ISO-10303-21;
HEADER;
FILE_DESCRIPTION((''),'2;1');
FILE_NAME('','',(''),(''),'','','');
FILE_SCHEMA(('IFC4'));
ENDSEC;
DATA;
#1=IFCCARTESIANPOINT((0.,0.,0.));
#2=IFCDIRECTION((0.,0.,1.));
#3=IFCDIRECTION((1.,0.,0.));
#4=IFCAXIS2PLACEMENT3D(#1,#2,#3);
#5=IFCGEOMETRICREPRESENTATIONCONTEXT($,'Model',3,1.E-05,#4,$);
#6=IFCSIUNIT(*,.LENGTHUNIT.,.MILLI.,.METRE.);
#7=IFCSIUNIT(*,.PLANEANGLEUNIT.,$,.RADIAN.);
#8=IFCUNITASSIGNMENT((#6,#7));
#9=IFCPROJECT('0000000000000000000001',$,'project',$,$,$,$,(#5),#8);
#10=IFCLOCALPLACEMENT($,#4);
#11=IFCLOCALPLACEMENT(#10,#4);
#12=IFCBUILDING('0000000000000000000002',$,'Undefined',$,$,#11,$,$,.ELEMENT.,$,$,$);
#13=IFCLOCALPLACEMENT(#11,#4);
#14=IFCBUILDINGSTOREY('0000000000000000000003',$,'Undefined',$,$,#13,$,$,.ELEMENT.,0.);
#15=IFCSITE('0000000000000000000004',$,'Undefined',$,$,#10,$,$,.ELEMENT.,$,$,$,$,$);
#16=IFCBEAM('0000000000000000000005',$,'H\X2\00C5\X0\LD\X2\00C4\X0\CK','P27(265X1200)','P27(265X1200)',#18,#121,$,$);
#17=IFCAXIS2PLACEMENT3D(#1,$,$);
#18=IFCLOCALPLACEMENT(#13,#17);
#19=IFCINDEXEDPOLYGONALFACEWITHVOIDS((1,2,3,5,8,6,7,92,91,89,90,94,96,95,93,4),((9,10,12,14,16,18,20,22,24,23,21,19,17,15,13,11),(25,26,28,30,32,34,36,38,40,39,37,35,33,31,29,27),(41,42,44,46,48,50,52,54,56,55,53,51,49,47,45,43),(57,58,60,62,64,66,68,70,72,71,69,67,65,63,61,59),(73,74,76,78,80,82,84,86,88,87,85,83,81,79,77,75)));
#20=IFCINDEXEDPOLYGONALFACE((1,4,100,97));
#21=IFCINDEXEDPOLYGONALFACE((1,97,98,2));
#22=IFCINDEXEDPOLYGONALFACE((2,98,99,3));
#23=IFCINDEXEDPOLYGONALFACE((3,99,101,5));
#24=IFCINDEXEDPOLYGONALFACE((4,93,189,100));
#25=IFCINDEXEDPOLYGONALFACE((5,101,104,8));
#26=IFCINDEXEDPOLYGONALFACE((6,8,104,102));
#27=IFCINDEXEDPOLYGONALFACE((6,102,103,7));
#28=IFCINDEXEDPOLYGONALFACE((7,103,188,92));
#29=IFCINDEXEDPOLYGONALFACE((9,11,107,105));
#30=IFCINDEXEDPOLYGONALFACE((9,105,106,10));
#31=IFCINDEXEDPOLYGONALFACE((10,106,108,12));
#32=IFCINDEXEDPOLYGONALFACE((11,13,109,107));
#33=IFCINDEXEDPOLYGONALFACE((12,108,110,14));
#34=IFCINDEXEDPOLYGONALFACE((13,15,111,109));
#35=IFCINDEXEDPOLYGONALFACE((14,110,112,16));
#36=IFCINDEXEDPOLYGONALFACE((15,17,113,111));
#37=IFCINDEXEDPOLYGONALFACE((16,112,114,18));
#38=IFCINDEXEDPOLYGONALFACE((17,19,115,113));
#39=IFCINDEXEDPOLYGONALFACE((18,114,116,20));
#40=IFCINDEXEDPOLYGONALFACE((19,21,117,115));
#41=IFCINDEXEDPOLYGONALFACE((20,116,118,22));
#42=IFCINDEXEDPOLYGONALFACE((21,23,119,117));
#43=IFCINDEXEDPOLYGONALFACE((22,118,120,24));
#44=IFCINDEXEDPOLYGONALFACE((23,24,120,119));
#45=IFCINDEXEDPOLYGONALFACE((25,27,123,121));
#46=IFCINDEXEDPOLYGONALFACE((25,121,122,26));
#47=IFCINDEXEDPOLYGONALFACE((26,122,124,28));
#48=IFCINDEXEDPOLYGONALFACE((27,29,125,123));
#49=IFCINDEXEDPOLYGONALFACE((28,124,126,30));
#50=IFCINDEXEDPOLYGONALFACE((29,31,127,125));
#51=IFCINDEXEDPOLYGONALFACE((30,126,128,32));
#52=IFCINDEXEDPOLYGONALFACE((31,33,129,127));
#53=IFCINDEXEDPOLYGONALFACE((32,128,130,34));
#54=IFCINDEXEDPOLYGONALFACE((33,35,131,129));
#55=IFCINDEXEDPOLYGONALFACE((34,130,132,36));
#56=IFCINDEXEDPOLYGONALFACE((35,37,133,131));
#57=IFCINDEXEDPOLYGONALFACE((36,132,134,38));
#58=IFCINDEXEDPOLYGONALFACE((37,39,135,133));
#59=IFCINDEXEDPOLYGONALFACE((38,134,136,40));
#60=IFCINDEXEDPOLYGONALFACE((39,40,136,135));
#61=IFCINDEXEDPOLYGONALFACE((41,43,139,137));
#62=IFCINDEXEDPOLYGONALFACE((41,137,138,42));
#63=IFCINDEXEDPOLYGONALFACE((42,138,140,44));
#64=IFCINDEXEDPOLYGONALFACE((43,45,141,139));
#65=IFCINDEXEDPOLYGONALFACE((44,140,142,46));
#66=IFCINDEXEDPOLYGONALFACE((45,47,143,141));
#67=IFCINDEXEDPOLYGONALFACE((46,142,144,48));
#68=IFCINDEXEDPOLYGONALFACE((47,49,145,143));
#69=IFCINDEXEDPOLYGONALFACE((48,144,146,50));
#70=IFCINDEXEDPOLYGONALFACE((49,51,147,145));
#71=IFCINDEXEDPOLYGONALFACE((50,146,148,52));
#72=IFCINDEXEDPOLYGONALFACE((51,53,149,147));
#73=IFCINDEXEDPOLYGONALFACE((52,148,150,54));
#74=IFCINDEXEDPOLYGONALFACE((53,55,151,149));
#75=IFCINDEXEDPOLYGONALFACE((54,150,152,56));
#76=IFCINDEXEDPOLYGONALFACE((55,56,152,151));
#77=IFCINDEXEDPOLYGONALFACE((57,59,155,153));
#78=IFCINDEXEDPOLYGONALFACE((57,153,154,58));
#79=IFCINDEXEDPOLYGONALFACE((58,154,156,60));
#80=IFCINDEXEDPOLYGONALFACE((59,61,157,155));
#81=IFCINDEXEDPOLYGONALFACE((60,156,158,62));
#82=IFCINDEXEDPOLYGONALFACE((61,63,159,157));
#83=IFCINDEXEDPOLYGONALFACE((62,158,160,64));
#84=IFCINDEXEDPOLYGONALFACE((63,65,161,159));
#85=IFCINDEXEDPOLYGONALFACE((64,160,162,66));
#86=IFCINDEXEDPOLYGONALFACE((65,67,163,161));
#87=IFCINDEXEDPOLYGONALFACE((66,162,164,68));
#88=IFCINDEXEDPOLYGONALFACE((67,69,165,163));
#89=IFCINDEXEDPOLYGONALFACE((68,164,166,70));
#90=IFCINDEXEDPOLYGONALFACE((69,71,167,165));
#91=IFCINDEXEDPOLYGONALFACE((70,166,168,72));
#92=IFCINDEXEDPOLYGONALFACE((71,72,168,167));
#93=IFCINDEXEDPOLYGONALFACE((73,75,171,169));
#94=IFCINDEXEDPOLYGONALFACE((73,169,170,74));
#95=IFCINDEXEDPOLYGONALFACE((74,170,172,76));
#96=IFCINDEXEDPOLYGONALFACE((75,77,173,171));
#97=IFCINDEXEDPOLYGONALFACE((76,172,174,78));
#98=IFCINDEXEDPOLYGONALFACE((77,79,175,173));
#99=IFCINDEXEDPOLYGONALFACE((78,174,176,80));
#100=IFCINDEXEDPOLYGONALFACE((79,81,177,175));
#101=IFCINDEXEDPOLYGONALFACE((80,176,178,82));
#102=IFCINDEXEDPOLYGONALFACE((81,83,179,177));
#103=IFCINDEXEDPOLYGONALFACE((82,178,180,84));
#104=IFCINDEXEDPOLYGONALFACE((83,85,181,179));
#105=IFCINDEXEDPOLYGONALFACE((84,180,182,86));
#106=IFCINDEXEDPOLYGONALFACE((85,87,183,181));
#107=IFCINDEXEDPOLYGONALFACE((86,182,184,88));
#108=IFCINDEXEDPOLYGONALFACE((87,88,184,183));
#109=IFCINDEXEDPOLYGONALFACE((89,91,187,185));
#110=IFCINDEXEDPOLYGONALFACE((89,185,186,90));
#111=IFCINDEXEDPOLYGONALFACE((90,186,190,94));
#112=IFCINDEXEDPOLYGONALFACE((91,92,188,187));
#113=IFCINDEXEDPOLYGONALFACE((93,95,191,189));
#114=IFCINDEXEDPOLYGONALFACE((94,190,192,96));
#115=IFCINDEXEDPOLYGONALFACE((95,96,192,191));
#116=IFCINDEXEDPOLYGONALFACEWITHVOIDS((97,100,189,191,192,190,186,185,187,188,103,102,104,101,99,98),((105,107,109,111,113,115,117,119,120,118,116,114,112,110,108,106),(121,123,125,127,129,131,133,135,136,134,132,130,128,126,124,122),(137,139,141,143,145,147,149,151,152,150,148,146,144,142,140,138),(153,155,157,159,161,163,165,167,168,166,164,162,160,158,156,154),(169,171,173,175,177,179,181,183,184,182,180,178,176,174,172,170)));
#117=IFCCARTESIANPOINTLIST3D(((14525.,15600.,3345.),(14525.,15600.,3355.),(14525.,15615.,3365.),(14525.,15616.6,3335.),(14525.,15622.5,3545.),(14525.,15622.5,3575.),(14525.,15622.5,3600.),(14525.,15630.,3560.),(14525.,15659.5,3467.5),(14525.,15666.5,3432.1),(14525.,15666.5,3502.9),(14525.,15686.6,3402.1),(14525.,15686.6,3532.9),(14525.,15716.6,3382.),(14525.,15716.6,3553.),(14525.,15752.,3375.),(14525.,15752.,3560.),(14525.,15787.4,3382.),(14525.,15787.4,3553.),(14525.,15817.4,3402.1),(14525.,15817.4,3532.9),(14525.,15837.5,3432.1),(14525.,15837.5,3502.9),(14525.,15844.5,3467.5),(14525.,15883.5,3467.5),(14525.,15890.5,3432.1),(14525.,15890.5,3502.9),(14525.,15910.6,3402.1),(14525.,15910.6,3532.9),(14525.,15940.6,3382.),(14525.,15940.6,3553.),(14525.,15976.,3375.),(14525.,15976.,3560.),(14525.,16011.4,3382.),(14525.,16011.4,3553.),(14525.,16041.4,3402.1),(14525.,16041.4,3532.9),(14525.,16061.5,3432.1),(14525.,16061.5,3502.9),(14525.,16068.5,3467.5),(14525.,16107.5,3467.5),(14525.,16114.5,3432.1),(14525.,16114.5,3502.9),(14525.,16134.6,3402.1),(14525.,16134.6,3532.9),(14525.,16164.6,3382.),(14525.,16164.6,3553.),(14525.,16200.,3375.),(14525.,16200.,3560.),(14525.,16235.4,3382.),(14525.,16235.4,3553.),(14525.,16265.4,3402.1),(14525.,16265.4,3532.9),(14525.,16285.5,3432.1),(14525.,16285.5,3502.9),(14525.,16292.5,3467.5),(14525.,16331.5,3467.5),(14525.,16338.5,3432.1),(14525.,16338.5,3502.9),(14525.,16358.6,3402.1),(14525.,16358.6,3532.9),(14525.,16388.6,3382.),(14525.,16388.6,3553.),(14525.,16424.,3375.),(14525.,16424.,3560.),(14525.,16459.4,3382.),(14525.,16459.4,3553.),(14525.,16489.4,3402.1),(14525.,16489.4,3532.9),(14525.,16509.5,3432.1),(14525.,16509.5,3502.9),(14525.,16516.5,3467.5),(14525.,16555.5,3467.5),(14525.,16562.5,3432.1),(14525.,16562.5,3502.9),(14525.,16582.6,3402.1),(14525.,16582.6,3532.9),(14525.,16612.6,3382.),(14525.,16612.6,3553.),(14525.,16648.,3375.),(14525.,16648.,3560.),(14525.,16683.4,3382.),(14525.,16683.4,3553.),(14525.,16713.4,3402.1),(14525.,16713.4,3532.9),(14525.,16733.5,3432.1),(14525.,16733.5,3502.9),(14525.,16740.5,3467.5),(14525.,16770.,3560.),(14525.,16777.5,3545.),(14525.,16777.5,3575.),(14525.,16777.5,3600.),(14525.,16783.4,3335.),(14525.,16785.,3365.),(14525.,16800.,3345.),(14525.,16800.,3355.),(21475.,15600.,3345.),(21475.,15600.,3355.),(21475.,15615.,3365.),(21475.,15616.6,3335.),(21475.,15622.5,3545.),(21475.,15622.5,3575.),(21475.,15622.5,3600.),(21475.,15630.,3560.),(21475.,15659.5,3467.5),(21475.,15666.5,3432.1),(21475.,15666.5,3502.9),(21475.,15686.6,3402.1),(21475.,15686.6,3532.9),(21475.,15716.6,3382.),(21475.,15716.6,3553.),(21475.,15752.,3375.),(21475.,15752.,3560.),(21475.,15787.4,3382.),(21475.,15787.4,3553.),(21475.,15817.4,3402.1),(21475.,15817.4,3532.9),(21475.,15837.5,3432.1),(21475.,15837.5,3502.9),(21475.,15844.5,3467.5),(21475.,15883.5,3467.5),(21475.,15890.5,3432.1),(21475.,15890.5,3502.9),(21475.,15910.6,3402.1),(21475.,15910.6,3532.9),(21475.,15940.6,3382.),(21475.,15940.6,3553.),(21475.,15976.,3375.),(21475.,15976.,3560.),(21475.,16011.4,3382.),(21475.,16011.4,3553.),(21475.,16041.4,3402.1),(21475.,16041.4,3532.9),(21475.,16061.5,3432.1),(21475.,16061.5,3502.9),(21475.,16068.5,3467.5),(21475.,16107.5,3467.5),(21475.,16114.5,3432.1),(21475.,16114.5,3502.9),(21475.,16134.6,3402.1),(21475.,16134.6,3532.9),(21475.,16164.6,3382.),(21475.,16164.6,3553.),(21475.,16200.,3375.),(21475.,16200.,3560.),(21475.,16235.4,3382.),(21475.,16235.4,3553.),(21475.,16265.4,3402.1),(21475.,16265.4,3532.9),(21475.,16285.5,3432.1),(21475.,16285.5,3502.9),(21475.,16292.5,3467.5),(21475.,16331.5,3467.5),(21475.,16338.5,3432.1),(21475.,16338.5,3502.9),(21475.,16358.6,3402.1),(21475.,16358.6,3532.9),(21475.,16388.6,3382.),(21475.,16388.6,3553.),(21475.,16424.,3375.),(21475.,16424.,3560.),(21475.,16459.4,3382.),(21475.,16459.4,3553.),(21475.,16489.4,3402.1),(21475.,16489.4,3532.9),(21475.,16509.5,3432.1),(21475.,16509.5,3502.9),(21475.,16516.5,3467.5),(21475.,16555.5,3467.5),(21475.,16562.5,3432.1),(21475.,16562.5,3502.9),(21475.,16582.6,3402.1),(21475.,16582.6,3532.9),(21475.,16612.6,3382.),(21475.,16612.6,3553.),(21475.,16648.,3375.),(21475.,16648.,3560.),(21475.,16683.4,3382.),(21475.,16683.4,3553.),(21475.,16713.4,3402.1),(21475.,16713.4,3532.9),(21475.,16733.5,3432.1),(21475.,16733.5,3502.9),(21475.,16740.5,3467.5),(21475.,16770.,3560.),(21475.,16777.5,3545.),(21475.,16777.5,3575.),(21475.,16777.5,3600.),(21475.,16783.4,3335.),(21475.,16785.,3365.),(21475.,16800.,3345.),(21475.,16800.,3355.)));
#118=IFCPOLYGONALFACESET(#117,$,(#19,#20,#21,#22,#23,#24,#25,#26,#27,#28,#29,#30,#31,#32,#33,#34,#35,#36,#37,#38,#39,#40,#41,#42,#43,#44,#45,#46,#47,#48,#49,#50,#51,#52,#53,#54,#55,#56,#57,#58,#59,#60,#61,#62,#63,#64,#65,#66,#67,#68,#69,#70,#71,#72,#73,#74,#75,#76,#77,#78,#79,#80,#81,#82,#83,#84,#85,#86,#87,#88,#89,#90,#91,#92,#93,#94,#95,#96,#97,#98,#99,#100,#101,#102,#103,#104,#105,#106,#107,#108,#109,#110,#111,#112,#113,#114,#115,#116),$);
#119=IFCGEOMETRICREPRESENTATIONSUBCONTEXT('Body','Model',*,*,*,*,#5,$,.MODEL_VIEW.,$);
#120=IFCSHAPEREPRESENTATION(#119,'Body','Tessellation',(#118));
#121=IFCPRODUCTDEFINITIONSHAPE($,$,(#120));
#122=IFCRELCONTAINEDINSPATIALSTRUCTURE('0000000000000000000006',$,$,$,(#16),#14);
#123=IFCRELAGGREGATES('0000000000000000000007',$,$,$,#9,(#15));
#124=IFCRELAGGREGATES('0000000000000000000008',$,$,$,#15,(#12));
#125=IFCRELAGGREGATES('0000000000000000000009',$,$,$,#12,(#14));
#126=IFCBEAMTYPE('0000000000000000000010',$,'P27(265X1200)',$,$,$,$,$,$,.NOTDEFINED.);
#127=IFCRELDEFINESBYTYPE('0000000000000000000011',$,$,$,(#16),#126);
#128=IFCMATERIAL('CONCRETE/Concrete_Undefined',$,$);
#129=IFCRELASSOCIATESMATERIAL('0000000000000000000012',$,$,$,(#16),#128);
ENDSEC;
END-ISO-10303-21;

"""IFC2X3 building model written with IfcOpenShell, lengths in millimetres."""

from ifc_helpers import new_model, si_unit, frame, origin_with_axes, place, context, subcontext, project, spatial, polyline, outline, extrude, material, type_object, element, save


model = new_model("IFC2X3")

# Units and contexts
model_context = context("Model", 3, precision=1e-05, world=origin_with_axes())
body_context = subcontext(model_context, "Body", "Model", "MODEL_VIEW")
ifc_project = project(units=[si_unit("LENGTHUNIT", "METRE", prefix="MILLI"), si_unit("PLANEANGLEUNIT", "RADIAN")], contexts=[model_context])

# Site, building, storey
site_placement = place(None, origin_with_axes())
site = spatial("IfcSite", under=ifc_project, at=site_placement, Name="Undefined", CompositionType="ELEMENT")
building_placement = place(site_placement, origin_with_axes())
building = spatial("IfcBuilding", under=site, at=building_placement, Name="Undefined", CompositionType="ELEMENT")
storey_placement = place(building_placement, origin_with_axes())
storey = spatial("IfcBuildingStorey", under=building, at=storey_placement, Name="Undefined", CompositionType="ELEMENT", Elevation=0.0)

# Beam
ifc_material_1 = material(Name="CONCRETE/Concrete_Undefined")
beam_type_1 = type_object("IfcBeamType", Name="P27(265X1200)", PredefinedType="NOTDEFINED")
beam_1_placement = place(storey_placement, frame((14525.0, 16200.0, 3467.5), z_axis=(0.0, 0.0, 1.0), x_axis=(1.0, 0.0, 0.0)))
element("IfcBeam", 1, at=beam_1_placement, inside=storey, type_object=beam_type_1, material=ifc_material_1, Name="HÅLDÄCK", Description="P27(265X1200)", ObjectType="P27(265X1200)", context=body_context, shape_type="SweptSolid", body=[
    extrude(outline(polyline([(-583.4, -132.5), (-600.0, -122.5), (-600.0, -112.5), (-585.0, -102.5), (-577.5, 77.5), (-570.0, 92.5), (-577.5, 107.5), (-577.5, 132.5), (577.5, 132.5), (577.5, 107.5), (570.0, 92.5), (577.5, 77.5), (585.0, -102.5), (600.0, -112.5), (600.0, -122.5), (583.4, -132.5), (-583.4, -132.5)]), holes=[polyline([(-513.4, 65.4), (-533.5, 35.4), (-540.5, 0.0), (-533.5, -35.4), (-513.4, -65.4), (-483.4, -85.5), (-448.0, -92.5), (-412.6, -85.5), (-382.6, -65.4), (-362.5, -35.4), (-355.5, 0.0), (-362.5, 35.4), (-382.6, 65.4), (-412.6, 85.5), (-448.0, 92.5), (-483.4, 85.5), (-513.4, 65.4)]), polyline([(-289.4, 65.4), (-309.5, 35.4), (-316.5, 0.0), (-309.5, -35.4), (-289.4, -65.4), (-259.4, -85.5), (-224.0, -92.5), (-188.6, -85.5), (-158.6, -65.4), (-138.5, -35.4), (-131.5, 0.0), (-138.5, 35.4), (-158.6, 65.4), (-188.6, 85.5), (-224.0, 92.5), (-259.4, 85.5), (-289.4, 65.4)]), polyline([(-65.4, 65.4), (-85.5, 35.4), (-92.5, 0.0), (-85.5, -35.4), (-65.4, -65.4), (-35.4, -85.5), (0.0, -92.5), (35.4, -85.5), (65.4, -65.4), (85.5, -35.4), (92.5, 0.0), (85.5, 35.4), (65.4, 65.4), (35.4, 85.5), (0.0, 92.5), (-35.4, 85.5), (-65.4, 65.4)]), polyline([(158.6, 65.4), (138.5, 35.4), (131.5, 0.0), (138.5, -35.4), (158.6, -65.4), (188.6, -85.5), (224.0, -92.5), (259.4, -85.5), (289.4, -65.4), (309.5, -35.4), (316.5, 0.0), (309.5, 35.4), (289.4, 65.4), (259.4, 85.5), (224.0, 92.5), (188.6, 85.5), (158.6, 65.4)]), polyline([(382.6, 65.4), (362.5, 35.4), (355.5, 0.0), (362.5, -35.4), (382.6, -65.4), (412.6, -85.5), (448.0, -92.5), (483.4, -85.5), (513.4, -65.4), (533.5, -35.4), (540.5, 0.0), (533.5, 35.4), (513.4, 65.4), (483.4, 85.5), (448.0, 92.5), (412.6, 85.5), (382.6, 65.4)])]), frame((6950.0, 0.0, 0.0), z_axis=(-1.0, 0.0, 0.0), x_axis=(0.0, -1.0, 0.0)), (0.0, 0.0, 1.0), 6950.0),
])

save(model, "model.ifc")
